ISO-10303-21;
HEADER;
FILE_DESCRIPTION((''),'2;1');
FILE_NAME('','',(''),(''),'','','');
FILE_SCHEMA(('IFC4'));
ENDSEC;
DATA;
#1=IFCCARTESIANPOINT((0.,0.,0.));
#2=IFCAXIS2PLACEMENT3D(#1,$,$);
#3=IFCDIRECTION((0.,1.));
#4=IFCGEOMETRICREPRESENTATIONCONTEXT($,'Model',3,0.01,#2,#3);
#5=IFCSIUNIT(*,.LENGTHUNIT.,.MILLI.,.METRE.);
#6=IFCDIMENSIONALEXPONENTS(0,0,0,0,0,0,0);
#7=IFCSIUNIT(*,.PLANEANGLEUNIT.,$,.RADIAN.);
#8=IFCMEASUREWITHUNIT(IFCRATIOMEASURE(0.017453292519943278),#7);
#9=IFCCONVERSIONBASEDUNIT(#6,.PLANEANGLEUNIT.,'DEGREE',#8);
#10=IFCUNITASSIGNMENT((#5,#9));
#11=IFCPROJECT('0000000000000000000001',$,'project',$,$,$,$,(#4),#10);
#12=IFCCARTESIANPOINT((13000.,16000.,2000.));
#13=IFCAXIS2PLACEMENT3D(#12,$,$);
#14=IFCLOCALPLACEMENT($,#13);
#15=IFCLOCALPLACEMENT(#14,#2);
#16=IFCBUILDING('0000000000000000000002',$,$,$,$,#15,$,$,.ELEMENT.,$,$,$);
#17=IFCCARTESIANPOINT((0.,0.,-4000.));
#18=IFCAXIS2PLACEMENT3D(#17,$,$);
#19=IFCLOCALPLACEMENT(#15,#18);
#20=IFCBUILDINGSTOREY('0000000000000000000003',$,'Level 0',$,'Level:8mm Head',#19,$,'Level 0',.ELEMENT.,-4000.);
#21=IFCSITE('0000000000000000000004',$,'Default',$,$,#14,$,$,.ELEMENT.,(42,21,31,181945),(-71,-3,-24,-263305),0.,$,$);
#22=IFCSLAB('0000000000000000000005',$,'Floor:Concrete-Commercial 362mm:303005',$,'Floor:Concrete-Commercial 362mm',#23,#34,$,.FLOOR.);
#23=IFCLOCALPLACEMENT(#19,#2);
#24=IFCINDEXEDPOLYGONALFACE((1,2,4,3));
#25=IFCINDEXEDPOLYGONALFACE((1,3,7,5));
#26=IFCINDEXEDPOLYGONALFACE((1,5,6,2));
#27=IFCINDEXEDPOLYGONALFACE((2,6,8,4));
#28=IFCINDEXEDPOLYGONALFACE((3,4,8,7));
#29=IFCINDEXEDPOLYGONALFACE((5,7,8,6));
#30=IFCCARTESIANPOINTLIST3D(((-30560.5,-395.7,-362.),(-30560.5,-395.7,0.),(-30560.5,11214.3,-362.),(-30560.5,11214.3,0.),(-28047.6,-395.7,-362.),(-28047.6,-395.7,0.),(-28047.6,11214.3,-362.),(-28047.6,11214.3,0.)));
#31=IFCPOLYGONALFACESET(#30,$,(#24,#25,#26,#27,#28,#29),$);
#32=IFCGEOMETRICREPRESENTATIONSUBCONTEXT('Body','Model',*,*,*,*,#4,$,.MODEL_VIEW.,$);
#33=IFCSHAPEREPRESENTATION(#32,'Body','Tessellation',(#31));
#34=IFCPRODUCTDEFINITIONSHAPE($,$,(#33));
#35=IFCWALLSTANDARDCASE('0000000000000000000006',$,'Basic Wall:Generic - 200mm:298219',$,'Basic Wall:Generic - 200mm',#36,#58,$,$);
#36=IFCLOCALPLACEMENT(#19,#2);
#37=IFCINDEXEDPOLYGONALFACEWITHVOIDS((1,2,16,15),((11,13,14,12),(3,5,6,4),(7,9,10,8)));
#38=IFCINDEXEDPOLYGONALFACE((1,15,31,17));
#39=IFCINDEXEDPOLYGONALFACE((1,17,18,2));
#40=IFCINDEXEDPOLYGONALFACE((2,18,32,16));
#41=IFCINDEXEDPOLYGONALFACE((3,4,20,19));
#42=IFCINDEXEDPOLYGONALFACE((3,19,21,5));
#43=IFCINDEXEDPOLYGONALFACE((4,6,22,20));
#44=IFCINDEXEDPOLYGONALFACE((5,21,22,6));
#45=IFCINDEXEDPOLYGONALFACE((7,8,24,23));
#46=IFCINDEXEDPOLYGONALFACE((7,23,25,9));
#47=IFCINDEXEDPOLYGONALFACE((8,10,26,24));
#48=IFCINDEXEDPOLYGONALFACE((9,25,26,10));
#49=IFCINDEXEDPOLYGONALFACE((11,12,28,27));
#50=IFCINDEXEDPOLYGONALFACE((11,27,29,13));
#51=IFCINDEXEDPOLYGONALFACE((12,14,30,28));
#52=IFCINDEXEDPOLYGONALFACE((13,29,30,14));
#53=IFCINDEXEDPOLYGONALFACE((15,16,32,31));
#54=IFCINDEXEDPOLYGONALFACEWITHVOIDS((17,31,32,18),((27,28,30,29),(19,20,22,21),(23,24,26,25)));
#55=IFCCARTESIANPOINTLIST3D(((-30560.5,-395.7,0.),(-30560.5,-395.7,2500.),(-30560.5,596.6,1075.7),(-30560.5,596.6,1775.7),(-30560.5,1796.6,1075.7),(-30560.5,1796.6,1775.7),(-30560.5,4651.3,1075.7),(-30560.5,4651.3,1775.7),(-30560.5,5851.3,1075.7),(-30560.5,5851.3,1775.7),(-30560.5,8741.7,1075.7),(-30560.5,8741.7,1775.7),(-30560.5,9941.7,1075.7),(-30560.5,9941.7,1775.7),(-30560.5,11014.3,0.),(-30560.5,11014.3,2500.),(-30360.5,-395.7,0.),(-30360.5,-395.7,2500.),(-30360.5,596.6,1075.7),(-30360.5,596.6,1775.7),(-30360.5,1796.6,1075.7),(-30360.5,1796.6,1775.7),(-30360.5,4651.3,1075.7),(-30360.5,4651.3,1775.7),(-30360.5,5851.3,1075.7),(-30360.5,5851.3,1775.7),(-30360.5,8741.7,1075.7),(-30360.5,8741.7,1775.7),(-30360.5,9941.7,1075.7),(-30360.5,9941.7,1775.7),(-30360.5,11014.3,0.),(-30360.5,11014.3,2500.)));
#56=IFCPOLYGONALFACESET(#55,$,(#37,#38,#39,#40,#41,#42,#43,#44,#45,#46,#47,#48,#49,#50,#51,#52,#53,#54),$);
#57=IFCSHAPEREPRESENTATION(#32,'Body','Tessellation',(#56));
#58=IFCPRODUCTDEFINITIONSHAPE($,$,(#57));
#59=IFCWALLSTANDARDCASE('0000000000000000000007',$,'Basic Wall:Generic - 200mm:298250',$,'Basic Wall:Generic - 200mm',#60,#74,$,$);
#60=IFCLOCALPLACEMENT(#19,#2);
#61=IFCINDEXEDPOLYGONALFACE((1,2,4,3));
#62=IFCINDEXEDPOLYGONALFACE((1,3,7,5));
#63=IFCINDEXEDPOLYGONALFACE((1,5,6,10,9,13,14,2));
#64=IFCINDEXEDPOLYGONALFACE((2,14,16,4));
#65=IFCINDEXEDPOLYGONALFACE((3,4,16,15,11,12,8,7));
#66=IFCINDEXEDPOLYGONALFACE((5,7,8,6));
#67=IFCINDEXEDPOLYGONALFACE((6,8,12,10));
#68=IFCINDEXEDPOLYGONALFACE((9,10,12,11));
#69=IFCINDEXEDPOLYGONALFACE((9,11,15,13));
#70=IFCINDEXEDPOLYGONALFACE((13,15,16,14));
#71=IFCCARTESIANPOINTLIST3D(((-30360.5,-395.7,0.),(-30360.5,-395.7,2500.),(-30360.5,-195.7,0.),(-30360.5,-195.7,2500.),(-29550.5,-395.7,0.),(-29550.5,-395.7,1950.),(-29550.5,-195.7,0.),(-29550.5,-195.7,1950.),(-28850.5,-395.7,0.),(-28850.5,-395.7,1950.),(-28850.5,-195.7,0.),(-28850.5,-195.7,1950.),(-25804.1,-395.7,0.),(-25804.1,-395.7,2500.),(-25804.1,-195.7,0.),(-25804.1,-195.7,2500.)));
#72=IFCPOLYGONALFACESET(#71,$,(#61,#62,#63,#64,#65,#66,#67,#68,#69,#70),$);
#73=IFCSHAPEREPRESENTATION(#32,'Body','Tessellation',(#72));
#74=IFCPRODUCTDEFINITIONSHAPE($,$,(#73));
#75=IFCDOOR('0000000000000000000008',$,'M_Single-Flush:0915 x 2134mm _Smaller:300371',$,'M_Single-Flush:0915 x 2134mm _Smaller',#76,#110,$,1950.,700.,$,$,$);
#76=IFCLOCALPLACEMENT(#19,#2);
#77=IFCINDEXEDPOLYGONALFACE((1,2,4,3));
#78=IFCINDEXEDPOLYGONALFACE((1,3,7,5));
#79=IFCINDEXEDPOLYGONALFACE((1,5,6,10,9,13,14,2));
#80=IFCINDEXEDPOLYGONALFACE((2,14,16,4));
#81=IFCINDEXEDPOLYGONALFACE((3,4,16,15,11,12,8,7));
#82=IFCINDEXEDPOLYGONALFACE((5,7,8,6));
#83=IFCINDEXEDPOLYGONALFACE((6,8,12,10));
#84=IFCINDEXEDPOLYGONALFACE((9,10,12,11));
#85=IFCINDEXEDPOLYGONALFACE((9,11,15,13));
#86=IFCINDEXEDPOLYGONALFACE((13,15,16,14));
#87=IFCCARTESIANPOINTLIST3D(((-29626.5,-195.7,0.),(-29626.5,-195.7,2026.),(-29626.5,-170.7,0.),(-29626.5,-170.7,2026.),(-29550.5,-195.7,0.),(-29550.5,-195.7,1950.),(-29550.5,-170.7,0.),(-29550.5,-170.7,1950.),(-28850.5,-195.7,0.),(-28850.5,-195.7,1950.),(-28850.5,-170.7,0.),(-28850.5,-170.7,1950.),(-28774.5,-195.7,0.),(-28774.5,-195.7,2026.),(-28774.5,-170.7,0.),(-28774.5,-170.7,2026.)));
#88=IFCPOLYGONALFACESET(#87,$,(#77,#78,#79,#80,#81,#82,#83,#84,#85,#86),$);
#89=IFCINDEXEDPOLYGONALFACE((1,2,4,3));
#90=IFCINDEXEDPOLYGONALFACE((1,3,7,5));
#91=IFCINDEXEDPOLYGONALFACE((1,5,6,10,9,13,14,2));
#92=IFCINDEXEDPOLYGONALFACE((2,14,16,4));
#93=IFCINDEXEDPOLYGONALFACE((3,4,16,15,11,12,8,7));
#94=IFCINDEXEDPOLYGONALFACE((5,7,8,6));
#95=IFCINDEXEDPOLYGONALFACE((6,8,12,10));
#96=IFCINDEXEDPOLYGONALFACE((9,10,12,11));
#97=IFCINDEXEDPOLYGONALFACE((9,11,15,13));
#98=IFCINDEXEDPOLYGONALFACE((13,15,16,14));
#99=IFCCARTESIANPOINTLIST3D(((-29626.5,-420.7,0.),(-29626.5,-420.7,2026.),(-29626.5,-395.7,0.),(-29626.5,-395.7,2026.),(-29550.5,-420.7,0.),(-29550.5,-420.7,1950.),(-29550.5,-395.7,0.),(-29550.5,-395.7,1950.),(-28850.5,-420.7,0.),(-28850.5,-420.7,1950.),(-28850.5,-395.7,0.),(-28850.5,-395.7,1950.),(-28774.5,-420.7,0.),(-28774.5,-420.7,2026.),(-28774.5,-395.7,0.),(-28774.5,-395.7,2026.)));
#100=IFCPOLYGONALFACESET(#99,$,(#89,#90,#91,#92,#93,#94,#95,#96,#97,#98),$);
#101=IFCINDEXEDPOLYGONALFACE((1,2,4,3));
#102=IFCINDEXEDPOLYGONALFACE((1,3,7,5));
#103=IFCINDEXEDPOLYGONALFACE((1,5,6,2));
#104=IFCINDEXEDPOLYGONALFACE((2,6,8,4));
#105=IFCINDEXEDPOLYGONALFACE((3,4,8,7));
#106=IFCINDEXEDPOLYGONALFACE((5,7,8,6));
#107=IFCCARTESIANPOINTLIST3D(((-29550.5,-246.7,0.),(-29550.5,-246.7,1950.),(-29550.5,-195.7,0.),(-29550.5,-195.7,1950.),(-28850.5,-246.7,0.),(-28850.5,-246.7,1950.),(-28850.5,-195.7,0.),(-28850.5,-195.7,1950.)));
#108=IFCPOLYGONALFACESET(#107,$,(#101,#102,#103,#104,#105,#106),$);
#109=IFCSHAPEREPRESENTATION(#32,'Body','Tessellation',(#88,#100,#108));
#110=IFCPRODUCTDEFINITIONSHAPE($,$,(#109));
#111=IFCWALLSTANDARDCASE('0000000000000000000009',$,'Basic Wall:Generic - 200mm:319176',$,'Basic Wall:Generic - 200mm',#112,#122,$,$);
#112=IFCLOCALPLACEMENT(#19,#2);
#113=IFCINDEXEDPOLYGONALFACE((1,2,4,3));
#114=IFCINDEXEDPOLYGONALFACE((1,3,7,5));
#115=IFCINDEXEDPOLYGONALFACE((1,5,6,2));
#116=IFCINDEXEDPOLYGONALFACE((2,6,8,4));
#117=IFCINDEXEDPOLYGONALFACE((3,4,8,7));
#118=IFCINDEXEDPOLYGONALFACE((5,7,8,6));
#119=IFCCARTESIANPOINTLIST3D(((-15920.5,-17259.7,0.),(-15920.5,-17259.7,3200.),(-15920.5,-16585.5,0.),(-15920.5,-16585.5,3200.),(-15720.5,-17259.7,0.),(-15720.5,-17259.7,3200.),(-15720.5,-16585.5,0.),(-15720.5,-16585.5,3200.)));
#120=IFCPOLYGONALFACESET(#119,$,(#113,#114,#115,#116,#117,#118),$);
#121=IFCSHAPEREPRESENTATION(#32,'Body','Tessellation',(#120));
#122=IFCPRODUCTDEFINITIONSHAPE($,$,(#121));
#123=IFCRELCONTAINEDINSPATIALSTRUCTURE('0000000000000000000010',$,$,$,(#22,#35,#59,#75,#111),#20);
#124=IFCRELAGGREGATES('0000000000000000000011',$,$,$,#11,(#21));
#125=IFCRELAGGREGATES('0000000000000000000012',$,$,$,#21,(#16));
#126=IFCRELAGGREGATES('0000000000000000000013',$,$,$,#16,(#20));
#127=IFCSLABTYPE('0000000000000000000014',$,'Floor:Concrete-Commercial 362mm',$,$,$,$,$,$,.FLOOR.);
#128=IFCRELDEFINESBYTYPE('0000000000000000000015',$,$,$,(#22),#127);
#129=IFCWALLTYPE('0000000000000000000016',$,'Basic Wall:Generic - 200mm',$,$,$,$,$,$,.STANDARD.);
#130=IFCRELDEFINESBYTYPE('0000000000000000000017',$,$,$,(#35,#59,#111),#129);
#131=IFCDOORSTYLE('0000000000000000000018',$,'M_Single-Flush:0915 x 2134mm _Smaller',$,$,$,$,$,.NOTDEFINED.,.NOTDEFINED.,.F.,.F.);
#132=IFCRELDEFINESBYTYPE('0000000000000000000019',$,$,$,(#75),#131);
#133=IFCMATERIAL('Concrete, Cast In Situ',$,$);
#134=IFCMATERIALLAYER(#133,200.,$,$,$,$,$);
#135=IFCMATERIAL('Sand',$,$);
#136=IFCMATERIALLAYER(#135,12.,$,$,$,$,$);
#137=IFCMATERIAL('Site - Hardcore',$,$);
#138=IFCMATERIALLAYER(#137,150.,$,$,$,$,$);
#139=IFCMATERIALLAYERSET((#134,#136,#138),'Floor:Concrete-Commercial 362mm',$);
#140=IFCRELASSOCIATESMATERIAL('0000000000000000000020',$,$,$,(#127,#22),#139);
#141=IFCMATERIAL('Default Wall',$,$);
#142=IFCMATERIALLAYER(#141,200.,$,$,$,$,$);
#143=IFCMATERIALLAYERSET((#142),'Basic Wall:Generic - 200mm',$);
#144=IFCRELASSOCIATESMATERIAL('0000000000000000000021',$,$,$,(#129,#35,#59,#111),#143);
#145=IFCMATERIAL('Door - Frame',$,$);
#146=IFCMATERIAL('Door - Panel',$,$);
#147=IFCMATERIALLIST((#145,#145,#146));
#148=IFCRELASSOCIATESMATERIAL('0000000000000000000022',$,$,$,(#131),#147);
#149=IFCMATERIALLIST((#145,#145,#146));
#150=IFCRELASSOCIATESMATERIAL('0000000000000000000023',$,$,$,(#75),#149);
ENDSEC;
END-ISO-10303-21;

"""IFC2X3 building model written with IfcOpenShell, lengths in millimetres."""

from ifc_helpers import new_model, entity, si_unit, converted_unit, direction, frame, frame_2d, origin, origin_2d_with_axis, place, context, subcontext, project, spatial, polyline, rectangle, outline, extrude, clip, bounded_halfspace, source, transform, mapped, material, material_list, layer, layer_set, layer_usage, type_object, type_shapes, element, fill, save


model = new_model("IFC2X3")

# Units and contexts
model_context = context("Model", 3, precision=0.01, world=origin(), true_north=direction((0.0, 1.0)))
body_context = subcontext(model_context, "Body", "Model", "MODEL_VIEW")
ifc_project = project(units=[si_unit("LENGTHUNIT", "METRE", prefix="MILLI"), converted_unit("PLANEANGLEUNIT", "DEGREE", entity("IfcRatioMeasure", 0.017453292519943278), si_unit("PLANEANGLEUNIT", "RADIAN"), dimensions=[0, 0, 0, 0, 0, 0, 0])], contexts=[model_context])

# Site, building, storey
site_placement = place(None, frame((13000.0, 16000.0, 2000.0)))
site = spatial("IfcSite", under=ifc_project, at=site_placement, Name="Default", CompositionType="ELEMENT", RefLatitude=(42, 21, 31, 181945), RefLongitude=(-71, -3, -24, -263305), RefElevation=0.0)
building_placement = place(site_placement, origin())
building = spatial("IfcBuilding", under=site, at=building_placement, CompositionType="ELEMENT")
storey_placement = place(building_placement, frame((0.0, 0.0, -4000.0)))
storey = spatial("IfcBuildingStorey", under=building, at=storey_placement, Name="Level 0", ObjectType="Level:8mm Head", LongName="Level 0", CompositionType="ELEMENT", Elevation=-4000.0)

# Slab
ifc_material_1 = material(Name="Concrete, Cast In Situ")
ifc_layer_1 = layer(ifc_material_1, 200.0)
ifc_material_2 = material(Name="Sand")
ifc_layer_2 = layer(ifc_material_2, 12.0)
ifc_material_3 = material(Name="Site - Hardcore")
ifc_layer_3 = layer(ifc_material_3, 150.0)
ifc_layer_set_1 = layer_set([ifc_layer_1, ifc_layer_2, ifc_layer_3], Name="Floor:Concrete-Commercial 362mm")
ifc_layer_usage_1 = layer_usage(ifc_layer_set_1, "AXIS3", "POSITIVE", 0.0)
slab_type = type_object("IfcSlabType", Name="Floor:Concrete-Commercial 362mm", PredefinedType="FLOOR", material=ifc_layer_set_1)
slab_placement = place(storey_placement, origin())
element("IfcSlab", 1, at=slab_placement, inside=storey, type_object=slab_type, material=ifc_layer_usage_1, Name="Floor:Concrete-Commercial 362mm:303005", ObjectType="Floor:Concrete-Commercial 362mm", PredefinedType="FLOOR", context=body_context, shape_type="SweptSolid", body=[
    extrude(rectangle(XDim=11610.0, YDim=2512.8, at=origin_2d_with_axis()), frame((-29304.1, 5409.3, 0.0), z_axis=(0.0, 0.0, -1.0), x_axis=(0.0, 1.0, 0.0)), (0.0, 0.0, 1.0), 362.0),
])

# Shared definitions
ifc_material_4 = material(Name="Default Wall")
ifc_layer_4 = layer(ifc_material_4, 200.0)
ifc_layer_set_2 = layer_set([ifc_layer_4], Name="Basic Wall:Generic - 200mm")
wall_type = type_object("IfcWallType", Name="Basic Wall:Generic - 200mm", PredefinedType="STANDARD", material=ifc_layer_set_2)

# Wall, openings
ifc_layer_usage_2 = layer_usage(ifc_layer_set_2, "AXIS2", "NEGATIVE", 100.0)
wall_1_placement = place(storey_placement, frame((-30460.5, 11014.3, 0.0), z_axis=(0.0, 0.0, 1.0), x_axis=(0.0, -1.0, 0.0)))
wall_1 = element("IfcWallStandardCase", 2, at=wall_1_placement, inside=storey, type_object=wall_type, material=ifc_layer_usage_2, Name="Basic Wall:Generic - 200mm:298219", ObjectType="Basic Wall:Generic - 200mm", context=body_context, shape_type="Clipping", body=[
    clip(extrude(rectangle(XDim=11410.0, YDim=200.0, at=frame_2d((5705.0, 0.0), x_axis=(-1.0, 0.0))), origin(), (0.0, 0.0, 1.0), 2500.0), bounded_halfspace(frame((0.0, -100.0, 2500.0), z_axis=(0.0, 0.0, -1.0), x_axis=(0.0, 1.0, 0.0)), True, frame((0.0, -100.0, 2500.0)), polyline([(0.0, 0.0), (3477782.0, 0.0), (3477782.0, 60960.0), (3416822.0, 60960.0), (0.0, 60960.0), (0.0, 0.0)]))),
])
opening_1_placement = place(wall_1_placement, frame((1072.6, -100.0, 1075.7)))
element("IfcOpeningElement", 3, at=opening_1_placement, cuts=wall_1, ObjectType="Opening", context=body_context, shape_type="SweptSolid", body=[
    extrude(rectangle(XDim=700.0, YDim=1200.0, at=frame_2d((350.0, 600.0), x_axis=(-1.0, 0.0))), frame((0.0, 0.0, 0.0), z_axis=(0.0, 1.0, 0.0), x_axis=(0.0, 0.0, 1.0)), (0.0, 0.0, 1.0), 200.0),
])
opening_2_placement = place(wall_1_placement, frame((5163.0, -100.0, 1075.7)))
element("IfcOpeningElement", 4, at=opening_2_placement, cuts=wall_1, ObjectType="Opening", context=body_context, shape_type="SweptSolid", body=[
    extrude(rectangle(XDim=700.0, YDim=1200.0, at=frame_2d((350.0, 600.0), x_axis=(-1.0, 0.0))), frame((0.0, 0.0, 0.0), z_axis=(0.0, 1.0, 0.0), x_axis=(0.0, 0.0, 1.0)), (0.0, 0.0, 1.0), 200.0),
])
opening_3_placement = place(wall_1_placement, frame((9217.8, -100.0, 1075.7)))
element("IfcOpeningElement", 5, at=opening_3_placement, cuts=wall_1, ObjectType="Opening", context=body_context, shape_type="SweptSolid", body=[
    extrude(rectangle(XDim=700.0, YDim=1200.0, at=frame_2d((350.0, 600.0), x_axis=(-1.0, 0.0))), frame((0.0, 0.0, 0.0), z_axis=(0.0, 1.0, 0.0), x_axis=(0.0, 0.0, 1.0)), (0.0, 0.0, 1.0), 200.0),
])

# Wall, opening, door
ifc_layer_usage_3 = layer_usage(ifc_layer_set_2, "AXIS2", "NEGATIVE", 100.0)
wall_2_placement = place(storey_placement, frame((-30360.5, -295.7, 0.0)))
wall_2 = element("IfcWallStandardCase", 6, at=wall_2_placement, inside=storey, type_object=wall_type, material=ifc_layer_usage_3, Name="Basic Wall:Generic - 200mm:298250", ObjectType="Basic Wall:Generic - 200mm", context=body_context, shape_type="Clipping", body=[
    clip(extrude(rectangle(XDim=200.0, YDim=4556.4, at=frame_2d((2278.2, 0.0), x_axis=(0.0, -1.0))), origin(), (0.0, 0.0, 1.0), 2500.0), bounded_halfspace(frame((0.0, 100.0, 2500.0), z_axis=(0.0, 0.0, -1.0), x_axis=(1.0, 0.0, 0.0)), True, frame((0.0, 100.0, 2500.0)), polyline([(0.0, 0.0), (0.0, -60960.0), (1388794.7, -60960.0), (1388794.7, 0.0), (0.0, 0.0)]))),
])
opening_4_placement = place(wall_2_placement, frame((810.0, -100.0, 0.0)))
opening_4 = element("IfcOpeningElement", 7, at=opening_4_placement, cuts=wall_2, ObjectType="Opening", context=body_context, shape_type="SweptSolid", body=[
    extrude(rectangle(XDim=700.0, YDim=1950.0, at=frame_2d((975.0, 350.0), x_axis=(0.0, -1.0))), frame((0.0, 0.0, 0.0), z_axis=(0.0, 1.0, 0.0), x_axis=(0.0, 0.0, 1.0)), (0.0, 0.0, 1.0), 200.0),
])
ifc_material_5 = material(Name="Door - Frame")
ifc_material_6 = material(Name="Door - Panel")
ifc_material_list_1 = material_list([ifc_material_5, ifc_material_5, ifc_material_6])
ifc_material_list_2 = material_list([ifc_material_5, ifc_material_5, ifc_material_6])
door_style = type_object("IfcDoorStyle", Name="M_Single-Flush:0915 x 2134mm _Smaller", ConstructionType="NOTDEFINED", OperationType="NOTDEFINED", ParameterTakesPrecedence=False, Sizeable=False, material=ifc_material_list_2)
shared_shape = source(origin(), body_context, "Body", "SweptSolid", [
    extrude(outline(polyline([(-426.0, -1032.0), (426.0, -1032.0), (426.0, 994.0), (350.0, 994.0), (350.0, -956.0), (-350.0, -956.0), (-350.0, 994.0), (-426.0, 994.0), (-426.0, -1032.0)])), frame((350.0, 225.0, 994.0), z_axis=(0.0, -1.0, 0.0), x_axis=(-1.0, 0.0, 0.0)), (0.0, 0.0, 1.0), 25.0),
    extrude(outline(polyline([(-1032.0, -426.0), (994.0, -426.0), (994.0, -350.0), (-956.0, -350.0), (-956.0, 350.0), (994.0, 350.0), (994.0, 426.0), (-1032.0, 426.0), (-1032.0, -426.0)])), frame((350.0, 0.0, 994.0), z_axis=(0.0, -1.0, 0.0), x_axis=(0.0, 0.0, -1.0)), (0.0, 0.0, 1.0), 25.0),
    extrude(rectangle(XDim=700.0, YDim=51.0, at=frame_2d((0.0, 0.0), x_axis=(1.0, 0.0))), frame((350.0, 174.5, 0.0)), (0.0, 0.0, 1.0), 1950.0),
])
type_shapes(door_style, [shared_shape])
door_placement = place(opening_4_placement, origin())
door = element("IfcDoor", 8, at=door_placement, inside=storey, type_object=door_style, material=ifc_material_list_1, Name="M_Single-Flush:0915 x 2134mm _Smaller:300371", ObjectType="M_Single-Flush:0915 x 2134mm _Smaller", OverallHeight=1950.0, OverallWidth=700.0, context=body_context, shape_type="MappedRepresentation", body=[
    mapped(shared_shape, transform((0.0, 0.0, 0.0), scale=1.0)),
])
fill(opening_4, door)

# Wall
ifc_layer_usage_4 = layer_usage(ifc_layer_set_2, "AXIS2", "NEGATIVE", 100.0)
wall_3_placement = place(storey_placement, frame((-15820.5, -16585.5, 0.0), z_axis=(0.0, 0.0, 1.0), x_axis=(0.0, -1.0, 0.0)))
element("IfcWallStandardCase", 9, at=wall_3_placement, inside=storey, type_object=wall_type, material=ifc_layer_usage_4, Name="Basic Wall:Generic - 200mm:319176", ObjectType="Basic Wall:Generic - 200mm", context=body_context, shape_type="SweptSolid", body=[
    extrude(rectangle(XDim=674.2, YDim=200.0, at=frame_2d((337.1, 0.0), x_axis=(-1.0, 0.0))), origin(), (0.0, 0.0, 1.0), 3200.0),
])

save(model, "model.ifc")
